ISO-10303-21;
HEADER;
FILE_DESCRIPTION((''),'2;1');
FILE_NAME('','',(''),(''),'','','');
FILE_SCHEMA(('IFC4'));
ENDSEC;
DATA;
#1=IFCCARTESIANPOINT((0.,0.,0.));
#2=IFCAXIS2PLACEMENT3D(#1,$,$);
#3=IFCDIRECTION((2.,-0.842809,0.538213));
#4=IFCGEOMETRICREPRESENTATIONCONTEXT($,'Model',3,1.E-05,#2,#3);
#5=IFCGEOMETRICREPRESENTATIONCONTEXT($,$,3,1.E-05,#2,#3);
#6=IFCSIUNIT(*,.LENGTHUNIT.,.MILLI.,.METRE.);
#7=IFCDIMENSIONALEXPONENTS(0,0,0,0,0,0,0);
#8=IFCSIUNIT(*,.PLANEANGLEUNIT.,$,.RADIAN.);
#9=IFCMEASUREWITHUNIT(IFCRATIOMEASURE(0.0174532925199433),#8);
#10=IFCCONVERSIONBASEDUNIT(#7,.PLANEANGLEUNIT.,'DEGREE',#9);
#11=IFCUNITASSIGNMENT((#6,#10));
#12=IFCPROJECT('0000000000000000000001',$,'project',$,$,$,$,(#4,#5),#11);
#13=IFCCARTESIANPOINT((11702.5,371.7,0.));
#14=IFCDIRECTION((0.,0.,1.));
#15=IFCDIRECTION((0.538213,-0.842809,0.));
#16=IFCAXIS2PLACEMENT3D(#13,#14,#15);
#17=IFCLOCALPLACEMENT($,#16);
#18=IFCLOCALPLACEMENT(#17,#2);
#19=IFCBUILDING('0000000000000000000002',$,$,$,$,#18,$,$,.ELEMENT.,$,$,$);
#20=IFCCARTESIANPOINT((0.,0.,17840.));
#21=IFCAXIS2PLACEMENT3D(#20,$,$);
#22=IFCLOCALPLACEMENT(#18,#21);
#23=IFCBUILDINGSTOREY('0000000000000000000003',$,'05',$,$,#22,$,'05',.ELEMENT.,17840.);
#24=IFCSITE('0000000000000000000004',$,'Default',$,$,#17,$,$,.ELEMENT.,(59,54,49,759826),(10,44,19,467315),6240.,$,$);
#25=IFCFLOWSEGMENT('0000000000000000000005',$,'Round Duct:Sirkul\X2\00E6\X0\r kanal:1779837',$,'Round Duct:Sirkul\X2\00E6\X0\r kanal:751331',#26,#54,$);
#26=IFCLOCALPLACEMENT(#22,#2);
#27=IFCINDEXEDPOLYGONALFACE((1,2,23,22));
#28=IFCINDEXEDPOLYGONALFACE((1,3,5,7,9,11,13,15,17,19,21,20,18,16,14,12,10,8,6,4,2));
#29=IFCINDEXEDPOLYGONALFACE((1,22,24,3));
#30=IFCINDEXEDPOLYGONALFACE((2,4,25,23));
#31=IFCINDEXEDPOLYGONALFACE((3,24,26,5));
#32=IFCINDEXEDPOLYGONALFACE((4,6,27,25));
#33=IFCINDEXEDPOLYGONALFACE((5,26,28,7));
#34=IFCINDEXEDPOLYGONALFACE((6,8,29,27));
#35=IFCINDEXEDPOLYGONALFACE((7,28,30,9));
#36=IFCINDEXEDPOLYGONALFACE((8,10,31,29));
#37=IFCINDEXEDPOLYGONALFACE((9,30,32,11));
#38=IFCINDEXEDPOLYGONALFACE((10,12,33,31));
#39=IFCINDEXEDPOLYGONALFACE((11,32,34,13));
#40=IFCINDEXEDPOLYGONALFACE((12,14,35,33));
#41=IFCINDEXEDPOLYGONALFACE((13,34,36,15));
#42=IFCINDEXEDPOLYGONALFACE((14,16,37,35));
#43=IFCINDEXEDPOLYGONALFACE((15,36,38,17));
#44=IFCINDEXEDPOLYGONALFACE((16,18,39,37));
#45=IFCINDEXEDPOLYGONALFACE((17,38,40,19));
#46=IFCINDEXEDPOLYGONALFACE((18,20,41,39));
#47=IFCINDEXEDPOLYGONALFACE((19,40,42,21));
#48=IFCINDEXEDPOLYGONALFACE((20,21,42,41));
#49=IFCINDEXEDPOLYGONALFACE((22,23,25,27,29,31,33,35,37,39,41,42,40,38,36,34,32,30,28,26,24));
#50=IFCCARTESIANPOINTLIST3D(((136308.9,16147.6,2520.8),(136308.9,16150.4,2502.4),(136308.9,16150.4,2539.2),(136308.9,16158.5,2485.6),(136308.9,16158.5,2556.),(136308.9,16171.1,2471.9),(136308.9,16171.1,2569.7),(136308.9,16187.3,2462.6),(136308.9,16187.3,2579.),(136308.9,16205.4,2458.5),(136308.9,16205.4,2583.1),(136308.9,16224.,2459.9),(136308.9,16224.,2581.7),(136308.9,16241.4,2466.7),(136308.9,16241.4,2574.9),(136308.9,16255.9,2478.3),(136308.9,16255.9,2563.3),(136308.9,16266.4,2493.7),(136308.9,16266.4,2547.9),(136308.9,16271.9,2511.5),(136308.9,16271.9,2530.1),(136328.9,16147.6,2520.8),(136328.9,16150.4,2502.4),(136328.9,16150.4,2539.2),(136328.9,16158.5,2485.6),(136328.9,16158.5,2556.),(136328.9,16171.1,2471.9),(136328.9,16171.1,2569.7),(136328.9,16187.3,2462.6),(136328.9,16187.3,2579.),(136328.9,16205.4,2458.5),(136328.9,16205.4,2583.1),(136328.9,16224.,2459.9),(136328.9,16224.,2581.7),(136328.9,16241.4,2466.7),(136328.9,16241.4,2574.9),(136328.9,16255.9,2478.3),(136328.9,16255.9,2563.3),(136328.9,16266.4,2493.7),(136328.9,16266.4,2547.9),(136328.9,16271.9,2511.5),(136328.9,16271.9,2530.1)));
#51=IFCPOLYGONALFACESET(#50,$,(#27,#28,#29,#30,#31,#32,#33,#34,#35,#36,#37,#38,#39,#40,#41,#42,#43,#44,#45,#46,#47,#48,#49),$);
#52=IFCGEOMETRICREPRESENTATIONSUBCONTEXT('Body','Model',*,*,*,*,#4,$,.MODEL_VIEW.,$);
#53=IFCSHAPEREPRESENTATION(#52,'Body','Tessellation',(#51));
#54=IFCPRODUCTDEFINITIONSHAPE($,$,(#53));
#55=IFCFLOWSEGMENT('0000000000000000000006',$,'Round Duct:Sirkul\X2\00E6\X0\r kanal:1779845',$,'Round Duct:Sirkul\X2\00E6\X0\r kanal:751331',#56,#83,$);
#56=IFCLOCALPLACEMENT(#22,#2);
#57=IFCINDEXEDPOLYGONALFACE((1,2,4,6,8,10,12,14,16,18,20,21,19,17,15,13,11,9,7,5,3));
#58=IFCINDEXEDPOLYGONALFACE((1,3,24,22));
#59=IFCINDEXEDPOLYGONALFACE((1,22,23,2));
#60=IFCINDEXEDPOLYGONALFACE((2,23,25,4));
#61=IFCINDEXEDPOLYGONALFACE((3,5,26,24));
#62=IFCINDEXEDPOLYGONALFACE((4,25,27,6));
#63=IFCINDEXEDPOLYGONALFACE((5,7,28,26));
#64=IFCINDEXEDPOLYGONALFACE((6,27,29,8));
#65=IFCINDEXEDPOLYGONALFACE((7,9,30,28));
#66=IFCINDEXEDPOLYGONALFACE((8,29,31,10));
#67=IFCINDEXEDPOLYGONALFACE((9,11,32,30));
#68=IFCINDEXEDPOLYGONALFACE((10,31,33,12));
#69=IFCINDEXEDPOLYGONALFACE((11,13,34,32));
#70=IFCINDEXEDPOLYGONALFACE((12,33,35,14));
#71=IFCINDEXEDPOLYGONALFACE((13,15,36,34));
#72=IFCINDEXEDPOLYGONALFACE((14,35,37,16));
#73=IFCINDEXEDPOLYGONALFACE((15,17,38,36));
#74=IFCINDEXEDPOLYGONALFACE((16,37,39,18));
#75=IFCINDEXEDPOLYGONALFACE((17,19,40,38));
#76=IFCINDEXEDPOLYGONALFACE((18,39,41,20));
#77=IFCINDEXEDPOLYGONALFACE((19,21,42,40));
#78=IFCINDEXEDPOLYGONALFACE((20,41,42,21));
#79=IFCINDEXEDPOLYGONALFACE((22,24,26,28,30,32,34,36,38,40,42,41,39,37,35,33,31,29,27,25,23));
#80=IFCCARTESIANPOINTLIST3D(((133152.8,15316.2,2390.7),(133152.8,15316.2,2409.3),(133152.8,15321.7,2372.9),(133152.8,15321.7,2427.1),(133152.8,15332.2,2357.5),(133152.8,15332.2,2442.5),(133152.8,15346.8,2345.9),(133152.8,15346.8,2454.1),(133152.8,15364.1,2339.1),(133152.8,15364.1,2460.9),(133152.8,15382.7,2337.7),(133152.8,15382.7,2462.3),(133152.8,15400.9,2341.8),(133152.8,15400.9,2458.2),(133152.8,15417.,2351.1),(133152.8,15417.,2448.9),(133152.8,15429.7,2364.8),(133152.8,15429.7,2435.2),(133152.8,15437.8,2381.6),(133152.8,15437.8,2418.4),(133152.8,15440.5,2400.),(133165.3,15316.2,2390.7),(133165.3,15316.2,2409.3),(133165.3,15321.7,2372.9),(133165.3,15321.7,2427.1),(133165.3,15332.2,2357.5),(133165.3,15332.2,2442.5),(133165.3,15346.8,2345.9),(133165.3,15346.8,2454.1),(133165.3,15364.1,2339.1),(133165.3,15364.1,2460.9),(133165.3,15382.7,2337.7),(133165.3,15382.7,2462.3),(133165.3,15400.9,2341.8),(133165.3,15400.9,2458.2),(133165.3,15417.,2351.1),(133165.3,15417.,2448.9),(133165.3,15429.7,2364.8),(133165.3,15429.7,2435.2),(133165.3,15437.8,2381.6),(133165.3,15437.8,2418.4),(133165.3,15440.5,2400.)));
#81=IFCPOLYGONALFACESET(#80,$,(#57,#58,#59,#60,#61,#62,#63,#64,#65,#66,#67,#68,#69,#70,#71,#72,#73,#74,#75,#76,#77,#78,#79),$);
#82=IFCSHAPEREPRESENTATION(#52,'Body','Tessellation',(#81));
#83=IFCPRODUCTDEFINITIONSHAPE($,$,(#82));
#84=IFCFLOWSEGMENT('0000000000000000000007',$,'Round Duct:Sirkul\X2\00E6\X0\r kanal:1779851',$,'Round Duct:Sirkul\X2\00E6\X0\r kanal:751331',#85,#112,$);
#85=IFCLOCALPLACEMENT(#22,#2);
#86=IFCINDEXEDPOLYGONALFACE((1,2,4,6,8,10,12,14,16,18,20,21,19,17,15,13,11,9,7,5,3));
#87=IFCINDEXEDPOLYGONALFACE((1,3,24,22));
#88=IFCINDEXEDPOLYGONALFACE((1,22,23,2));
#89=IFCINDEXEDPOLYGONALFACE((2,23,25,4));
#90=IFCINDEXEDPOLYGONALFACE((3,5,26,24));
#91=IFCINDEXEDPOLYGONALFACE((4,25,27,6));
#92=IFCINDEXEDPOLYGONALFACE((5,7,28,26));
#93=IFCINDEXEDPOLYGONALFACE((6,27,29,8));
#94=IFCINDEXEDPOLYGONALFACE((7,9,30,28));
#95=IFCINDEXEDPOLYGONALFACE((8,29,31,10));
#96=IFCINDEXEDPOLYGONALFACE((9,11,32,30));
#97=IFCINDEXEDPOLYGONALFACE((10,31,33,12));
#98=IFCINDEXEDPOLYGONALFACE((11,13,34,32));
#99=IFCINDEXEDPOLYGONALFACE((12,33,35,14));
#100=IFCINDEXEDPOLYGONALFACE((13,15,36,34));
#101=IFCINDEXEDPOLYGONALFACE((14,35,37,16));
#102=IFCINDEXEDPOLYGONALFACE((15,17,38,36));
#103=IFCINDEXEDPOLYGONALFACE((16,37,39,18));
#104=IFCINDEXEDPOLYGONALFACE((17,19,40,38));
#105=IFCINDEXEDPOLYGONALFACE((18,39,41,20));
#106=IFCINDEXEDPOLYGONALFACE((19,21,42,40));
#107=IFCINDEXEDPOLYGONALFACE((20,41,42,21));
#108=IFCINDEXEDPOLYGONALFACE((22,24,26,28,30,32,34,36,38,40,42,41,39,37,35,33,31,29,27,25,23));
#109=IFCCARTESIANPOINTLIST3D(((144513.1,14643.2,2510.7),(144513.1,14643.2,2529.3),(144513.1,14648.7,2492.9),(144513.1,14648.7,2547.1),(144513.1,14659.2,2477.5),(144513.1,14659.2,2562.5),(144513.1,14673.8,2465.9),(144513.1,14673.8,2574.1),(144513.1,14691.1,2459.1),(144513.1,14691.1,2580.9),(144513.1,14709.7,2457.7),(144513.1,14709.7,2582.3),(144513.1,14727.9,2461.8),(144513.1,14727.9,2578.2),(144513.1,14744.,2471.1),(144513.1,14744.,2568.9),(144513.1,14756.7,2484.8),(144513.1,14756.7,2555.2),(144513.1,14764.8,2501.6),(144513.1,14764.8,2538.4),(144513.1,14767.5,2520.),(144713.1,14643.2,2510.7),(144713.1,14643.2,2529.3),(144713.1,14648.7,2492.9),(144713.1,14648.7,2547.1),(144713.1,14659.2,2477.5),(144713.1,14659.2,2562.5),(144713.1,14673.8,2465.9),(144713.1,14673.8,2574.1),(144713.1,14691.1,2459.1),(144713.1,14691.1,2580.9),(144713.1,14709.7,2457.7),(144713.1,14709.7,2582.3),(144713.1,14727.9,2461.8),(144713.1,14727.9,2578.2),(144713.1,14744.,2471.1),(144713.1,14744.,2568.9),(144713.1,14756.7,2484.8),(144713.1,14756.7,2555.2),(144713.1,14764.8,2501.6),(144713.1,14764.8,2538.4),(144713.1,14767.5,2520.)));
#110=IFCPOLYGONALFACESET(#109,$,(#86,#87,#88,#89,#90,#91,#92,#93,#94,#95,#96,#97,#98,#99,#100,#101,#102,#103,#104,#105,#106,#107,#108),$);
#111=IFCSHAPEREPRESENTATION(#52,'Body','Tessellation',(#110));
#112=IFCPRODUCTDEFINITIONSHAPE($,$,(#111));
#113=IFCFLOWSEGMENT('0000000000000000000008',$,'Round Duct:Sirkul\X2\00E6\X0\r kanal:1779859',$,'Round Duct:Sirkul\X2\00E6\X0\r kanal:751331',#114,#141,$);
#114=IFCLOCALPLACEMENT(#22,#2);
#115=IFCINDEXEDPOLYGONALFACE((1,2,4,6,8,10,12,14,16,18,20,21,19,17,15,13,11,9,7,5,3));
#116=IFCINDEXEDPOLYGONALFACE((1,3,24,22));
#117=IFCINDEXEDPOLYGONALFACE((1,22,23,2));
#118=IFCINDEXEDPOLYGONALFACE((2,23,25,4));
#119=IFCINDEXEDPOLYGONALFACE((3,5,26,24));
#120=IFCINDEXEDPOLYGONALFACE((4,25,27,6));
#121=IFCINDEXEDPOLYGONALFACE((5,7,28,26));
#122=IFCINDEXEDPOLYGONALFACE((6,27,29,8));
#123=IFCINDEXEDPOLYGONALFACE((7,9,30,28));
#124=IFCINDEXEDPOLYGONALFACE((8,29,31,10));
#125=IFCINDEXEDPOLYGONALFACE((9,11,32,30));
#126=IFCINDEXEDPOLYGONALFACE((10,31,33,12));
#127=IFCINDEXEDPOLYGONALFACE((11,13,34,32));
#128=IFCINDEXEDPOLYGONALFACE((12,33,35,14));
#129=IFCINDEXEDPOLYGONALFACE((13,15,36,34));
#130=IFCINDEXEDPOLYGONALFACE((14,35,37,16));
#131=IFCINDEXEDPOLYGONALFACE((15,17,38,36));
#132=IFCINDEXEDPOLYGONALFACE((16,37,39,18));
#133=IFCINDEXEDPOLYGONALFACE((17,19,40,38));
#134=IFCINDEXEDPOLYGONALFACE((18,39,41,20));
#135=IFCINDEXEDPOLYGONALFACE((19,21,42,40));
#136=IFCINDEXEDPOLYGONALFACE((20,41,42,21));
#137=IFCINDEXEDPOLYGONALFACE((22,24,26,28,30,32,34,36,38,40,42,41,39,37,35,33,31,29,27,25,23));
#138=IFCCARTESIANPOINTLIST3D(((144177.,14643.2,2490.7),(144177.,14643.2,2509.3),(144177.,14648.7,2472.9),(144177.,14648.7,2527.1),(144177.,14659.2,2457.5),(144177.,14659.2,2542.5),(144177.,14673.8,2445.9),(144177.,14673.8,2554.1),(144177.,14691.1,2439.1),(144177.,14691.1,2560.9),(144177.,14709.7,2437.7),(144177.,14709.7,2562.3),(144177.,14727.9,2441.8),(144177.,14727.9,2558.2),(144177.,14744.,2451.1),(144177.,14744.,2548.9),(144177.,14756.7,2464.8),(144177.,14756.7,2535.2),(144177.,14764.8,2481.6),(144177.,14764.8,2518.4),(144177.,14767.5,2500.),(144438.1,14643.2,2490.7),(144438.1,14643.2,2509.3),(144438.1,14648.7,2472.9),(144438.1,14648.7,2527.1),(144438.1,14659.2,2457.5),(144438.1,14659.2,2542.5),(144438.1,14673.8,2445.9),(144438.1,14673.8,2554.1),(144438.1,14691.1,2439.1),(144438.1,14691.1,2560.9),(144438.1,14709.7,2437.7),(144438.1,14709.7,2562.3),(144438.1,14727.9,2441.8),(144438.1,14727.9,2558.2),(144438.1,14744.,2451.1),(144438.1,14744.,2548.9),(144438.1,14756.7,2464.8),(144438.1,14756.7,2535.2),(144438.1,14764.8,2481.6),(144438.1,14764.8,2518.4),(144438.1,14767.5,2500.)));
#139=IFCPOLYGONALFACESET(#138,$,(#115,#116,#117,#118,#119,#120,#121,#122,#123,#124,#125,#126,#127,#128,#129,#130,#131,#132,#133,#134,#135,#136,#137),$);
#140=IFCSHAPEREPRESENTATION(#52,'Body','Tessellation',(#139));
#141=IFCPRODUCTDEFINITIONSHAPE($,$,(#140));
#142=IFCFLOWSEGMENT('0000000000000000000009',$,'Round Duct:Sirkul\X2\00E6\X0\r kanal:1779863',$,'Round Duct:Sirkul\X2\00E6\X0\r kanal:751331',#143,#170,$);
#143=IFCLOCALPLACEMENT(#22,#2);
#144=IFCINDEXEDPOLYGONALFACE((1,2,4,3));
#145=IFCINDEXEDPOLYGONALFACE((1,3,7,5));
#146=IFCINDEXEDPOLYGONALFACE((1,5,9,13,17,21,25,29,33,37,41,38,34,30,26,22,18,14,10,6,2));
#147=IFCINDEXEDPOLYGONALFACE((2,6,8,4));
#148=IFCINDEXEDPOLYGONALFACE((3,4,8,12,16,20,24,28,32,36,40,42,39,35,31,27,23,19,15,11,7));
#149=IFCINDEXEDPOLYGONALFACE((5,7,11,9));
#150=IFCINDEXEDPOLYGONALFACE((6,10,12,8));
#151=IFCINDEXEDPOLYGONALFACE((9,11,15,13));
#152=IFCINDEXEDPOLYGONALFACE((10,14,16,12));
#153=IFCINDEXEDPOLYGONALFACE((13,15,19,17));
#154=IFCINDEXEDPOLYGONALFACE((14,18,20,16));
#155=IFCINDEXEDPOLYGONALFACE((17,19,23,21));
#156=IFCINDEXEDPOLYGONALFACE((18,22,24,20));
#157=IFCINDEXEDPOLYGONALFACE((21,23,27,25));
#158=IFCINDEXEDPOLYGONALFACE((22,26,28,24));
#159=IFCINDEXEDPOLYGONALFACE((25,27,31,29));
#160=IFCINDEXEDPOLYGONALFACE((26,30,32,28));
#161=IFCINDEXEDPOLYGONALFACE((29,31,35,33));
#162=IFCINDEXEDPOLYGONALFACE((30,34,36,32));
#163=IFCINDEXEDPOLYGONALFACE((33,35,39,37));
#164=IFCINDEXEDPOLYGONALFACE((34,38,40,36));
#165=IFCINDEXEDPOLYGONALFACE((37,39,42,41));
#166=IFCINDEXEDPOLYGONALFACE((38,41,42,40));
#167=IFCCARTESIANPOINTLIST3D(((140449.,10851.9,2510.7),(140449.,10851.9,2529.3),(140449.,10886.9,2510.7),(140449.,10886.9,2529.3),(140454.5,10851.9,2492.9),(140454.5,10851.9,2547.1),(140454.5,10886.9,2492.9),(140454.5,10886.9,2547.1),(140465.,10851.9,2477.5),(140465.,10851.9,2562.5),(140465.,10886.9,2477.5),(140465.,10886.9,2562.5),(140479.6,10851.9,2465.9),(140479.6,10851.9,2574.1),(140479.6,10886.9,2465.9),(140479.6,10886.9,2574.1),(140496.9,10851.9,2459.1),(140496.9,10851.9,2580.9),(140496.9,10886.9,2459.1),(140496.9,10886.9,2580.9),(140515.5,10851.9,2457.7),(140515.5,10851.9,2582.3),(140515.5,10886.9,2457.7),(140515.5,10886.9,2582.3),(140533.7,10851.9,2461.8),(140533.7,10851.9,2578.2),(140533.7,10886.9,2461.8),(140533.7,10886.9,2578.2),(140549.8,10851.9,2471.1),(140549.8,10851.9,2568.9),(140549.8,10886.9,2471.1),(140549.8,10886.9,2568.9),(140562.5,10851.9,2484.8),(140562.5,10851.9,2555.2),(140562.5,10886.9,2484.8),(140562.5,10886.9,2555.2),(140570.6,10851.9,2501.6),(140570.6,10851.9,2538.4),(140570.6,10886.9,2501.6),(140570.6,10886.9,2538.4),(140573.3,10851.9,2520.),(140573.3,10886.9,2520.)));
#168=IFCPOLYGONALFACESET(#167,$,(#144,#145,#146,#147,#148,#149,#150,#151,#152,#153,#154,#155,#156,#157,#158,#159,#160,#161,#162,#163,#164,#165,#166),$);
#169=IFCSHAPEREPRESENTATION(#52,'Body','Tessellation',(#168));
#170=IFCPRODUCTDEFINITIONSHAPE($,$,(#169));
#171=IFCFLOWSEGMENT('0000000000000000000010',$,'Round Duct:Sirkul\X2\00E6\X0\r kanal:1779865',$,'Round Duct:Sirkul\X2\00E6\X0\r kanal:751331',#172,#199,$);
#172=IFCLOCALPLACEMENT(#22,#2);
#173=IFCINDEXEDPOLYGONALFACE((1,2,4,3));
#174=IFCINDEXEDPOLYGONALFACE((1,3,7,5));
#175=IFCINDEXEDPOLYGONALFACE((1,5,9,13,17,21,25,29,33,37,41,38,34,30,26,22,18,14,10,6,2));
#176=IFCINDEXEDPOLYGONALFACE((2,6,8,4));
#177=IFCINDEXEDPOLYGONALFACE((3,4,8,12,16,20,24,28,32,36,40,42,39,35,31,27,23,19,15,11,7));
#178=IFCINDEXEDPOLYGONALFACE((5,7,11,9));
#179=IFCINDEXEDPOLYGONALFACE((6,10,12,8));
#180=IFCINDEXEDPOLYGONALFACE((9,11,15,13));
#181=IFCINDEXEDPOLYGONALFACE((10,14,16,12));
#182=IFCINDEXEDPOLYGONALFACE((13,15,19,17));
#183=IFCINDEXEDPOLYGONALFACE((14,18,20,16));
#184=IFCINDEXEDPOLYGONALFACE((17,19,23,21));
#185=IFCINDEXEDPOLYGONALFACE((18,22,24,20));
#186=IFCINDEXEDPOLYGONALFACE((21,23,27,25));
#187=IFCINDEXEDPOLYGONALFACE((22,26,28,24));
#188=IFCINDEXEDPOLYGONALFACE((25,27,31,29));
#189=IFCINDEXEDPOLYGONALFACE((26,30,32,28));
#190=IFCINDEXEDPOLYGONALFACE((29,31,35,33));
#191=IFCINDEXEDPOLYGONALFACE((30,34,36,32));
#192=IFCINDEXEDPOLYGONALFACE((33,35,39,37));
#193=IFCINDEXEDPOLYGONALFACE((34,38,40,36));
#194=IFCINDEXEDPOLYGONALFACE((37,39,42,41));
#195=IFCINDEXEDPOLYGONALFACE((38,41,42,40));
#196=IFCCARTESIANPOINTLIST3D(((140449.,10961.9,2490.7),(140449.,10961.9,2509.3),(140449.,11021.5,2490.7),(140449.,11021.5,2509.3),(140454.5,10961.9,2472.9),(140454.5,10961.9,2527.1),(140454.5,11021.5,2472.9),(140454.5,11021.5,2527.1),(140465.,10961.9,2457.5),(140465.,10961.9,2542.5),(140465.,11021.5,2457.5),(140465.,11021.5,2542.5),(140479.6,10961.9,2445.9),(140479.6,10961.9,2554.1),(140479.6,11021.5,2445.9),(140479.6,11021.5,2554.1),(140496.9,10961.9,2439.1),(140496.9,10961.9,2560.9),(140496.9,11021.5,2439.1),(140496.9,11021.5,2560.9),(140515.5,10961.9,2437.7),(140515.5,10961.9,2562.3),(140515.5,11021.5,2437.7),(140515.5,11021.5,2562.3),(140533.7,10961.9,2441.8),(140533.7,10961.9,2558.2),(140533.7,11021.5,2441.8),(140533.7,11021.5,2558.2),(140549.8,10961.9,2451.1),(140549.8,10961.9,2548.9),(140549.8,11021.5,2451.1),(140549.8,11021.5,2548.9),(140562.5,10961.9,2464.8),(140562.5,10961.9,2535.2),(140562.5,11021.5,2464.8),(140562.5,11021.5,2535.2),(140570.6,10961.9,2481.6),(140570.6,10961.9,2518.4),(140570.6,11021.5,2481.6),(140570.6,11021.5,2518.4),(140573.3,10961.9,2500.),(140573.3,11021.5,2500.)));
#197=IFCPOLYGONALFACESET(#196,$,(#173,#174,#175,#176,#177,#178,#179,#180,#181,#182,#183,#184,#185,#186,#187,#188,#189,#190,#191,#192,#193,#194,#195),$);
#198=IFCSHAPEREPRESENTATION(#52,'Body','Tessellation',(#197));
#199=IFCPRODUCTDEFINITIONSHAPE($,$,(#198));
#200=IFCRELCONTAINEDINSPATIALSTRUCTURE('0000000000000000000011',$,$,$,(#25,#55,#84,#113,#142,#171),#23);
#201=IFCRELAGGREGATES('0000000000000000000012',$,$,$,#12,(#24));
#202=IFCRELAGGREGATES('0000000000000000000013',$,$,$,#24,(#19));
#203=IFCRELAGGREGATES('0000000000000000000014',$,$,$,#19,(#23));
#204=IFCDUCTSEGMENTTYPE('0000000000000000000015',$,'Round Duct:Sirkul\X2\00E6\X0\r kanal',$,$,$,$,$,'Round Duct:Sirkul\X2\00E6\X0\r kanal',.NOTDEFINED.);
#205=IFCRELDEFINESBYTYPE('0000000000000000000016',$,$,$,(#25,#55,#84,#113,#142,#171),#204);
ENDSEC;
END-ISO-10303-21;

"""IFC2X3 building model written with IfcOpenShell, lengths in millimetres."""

from ifc_helpers import new_model, entity, si_unit, converted_unit, direction, frame, frame_2d, origin, origin_2d_with_axis, place, context, subcontext, project, spatial, circle, extrude, type_object, element, save


model = new_model("IFC2X3")

# Units and contexts
model_context = context("Model", 3, precision=1e-05, world=origin(), true_north=direction((2.0, -0.842809, 0.538213)))
context_of_model = context(None, 3, precision=1e-05, world=origin(), true_north=direction((2.0, -0.842809, 0.538213)))
body_context = subcontext(model_context, "Body", "Model", "MODEL_VIEW")
ifc_project = project(units=[si_unit("LENGTHUNIT", "METRE", prefix="MILLI"), converted_unit("PLANEANGLEUNIT", "DEGREE", entity("IfcRatioMeasure", 0.0174532925199433), si_unit("PLANEANGLEUNIT", "RADIAN"), dimensions=[0, 0, 0, 0, 0, 0, 0])], contexts=[model_context, context_of_model])

# Site, building, storey
site_placement = place(None, frame((11702.5, 371.7, 0.0), z_axis=(0.0, 0.0, 1.0), x_axis=(0.538213, -0.842809, 0.0)))
site = spatial("IfcSite", under=ifc_project, at=site_placement, Name="Default", CompositionType="ELEMENT", RefLatitude=(59, 54, 49, 759826), RefLongitude=(10, 44, 19, 467315), RefElevation=6240.0)
building_placement = place(site_placement, origin())
building = spatial("IfcBuilding", under=site, at=building_placement, CompositionType="ELEMENT")
storey_placement = place(building_placement, frame((0.0, 0.0, 17840.0)))
storey = spatial("IfcBuildingStorey", under=building, at=storey_placement, Name="05", LongName="05", CompositionType="ELEMENT", Elevation=17840.0)

# Flow segments
duct_segment_type_1 = type_object("IfcDuctSegmentType", Name="Round Duct:Sirkulær kanal", ElementType="Round Duct:Sirkulær kanal", PredefinedType="NOTDEFINED")
flow_segment_1_placement = place(storey_placement, origin())
element("IfcFlowSegment", 1, at=flow_segment_1_placement, inside=storey, type_object=duct_segment_type_1, Name="Round Duct:Sirkulær kanal:1779837", ObjectType="Round Duct:Sirkulær kanal:751331", context=body_context, shape_type="SweptSolid", body=[
    extrude(circle(Radius=62.5, at=frame_2d((0.0, 0.0), x_axis=(1.0, 0.0))), frame((136308.9, 16210.1, 2520.8), z_axis=(1.0, 0.0, 0.0), x_axis=(0.0, -1.0, 0.0)), (0.0, 0.0, 1.0), 20.0),
])
flow_segment_2_placement = place(storey_placement, origin())
element("IfcFlowSegment", 2, at=flow_segment_2_placement, inside=storey, type_object=duct_segment_type_1, Name="Round Duct:Sirkulær kanal:1779845", ObjectType="Round Duct:Sirkulær kanal:751331", context=body_context, shape_type="SweptSolid", body=[
    extrude(circle(Radius=62.5, at=frame_2d((0.0, 0.0), x_axis=(1.0, 0.0))), frame((133152.8, 15378.0, 2400.0), z_axis=(1.0, 0.0, 0.0), x_axis=(0.0, 1.0, 0.0)), (0.0, 0.0, 1.0), 12.5),
])
flow_segment_3_placement = place(storey_placement, origin())
element("IfcFlowSegment", 3, at=flow_segment_3_placement, inside=storey, type_object=duct_segment_type_1, Name="Round Duct:Sirkulær kanal:1779851", ObjectType="Round Duct:Sirkulær kanal:751331", context=body_context, shape_type="SweptSolid", body=[
    extrude(circle(Radius=62.5, at=origin_2d_with_axis()), frame((144513.1, 14705.0, 2520.0), z_axis=(1.0, 0.0, 0.0), x_axis=(0.0, 1.0, 0.0)), (0.0, 0.0, 1.0), 200.0),
])
flow_segment_4_placement = place(storey_placement, origin())
element("IfcFlowSegment", 4, at=flow_segment_4_placement, inside=storey, type_object=duct_segment_type_1, Name="Round Duct:Sirkulær kanal:1779859", ObjectType="Round Duct:Sirkulær kanal:751331", context=body_context, shape_type="SweptSolid", body=[
    extrude(circle(Radius=62.5, at=origin_2d_with_axis()), frame((144177.0, 14705.0, 2500.0), z_axis=(1.0, 0.0, 0.0), x_axis=(0.0, 1.0, 0.0)), (0.0, 0.0, 1.0), 261.0),
])
flow_segment_5_placement = place(storey_placement, origin())
element("IfcFlowSegment", 5, at=flow_segment_5_placement, inside=storey, type_object=duct_segment_type_1, Name="Round Duct:Sirkulær kanal:1779863", ObjectType="Round Duct:Sirkulær kanal:751331", context=body_context, shape_type="SweptSolid", body=[
    extrude(circle(Radius=62.5, at=frame_2d((0.0, 0.0), x_axis=(1.0, 0.0))), frame((140510.8, 10851.9, 2520.0), z_axis=(0.0, 1.0, 0.0), x_axis=(1.0, 0.0, 0.0)), (0.0, 0.0, 1.0), 35.0),
])
flow_segment_6_placement = place(storey_placement, origin())
element("IfcFlowSegment", 6, at=flow_segment_6_placement, inside=storey, type_object=duct_segment_type_1, Name="Round Duct:Sirkulær kanal:1779865", ObjectType="Round Duct:Sirkulær kanal:751331", context=body_context, shape_type="SweptSolid", body=[
    extrude(circle(Radius=62.5, at=origin_2d_with_axis()), frame((140510.8, 10961.9, 2500.0), z_axis=(0.0, 1.0, 0.0), x_axis=(1.0, 0.0, 0.0)), (0.0, 0.0, 1.0), 59.6),
])

save(model, "model.ifc")
